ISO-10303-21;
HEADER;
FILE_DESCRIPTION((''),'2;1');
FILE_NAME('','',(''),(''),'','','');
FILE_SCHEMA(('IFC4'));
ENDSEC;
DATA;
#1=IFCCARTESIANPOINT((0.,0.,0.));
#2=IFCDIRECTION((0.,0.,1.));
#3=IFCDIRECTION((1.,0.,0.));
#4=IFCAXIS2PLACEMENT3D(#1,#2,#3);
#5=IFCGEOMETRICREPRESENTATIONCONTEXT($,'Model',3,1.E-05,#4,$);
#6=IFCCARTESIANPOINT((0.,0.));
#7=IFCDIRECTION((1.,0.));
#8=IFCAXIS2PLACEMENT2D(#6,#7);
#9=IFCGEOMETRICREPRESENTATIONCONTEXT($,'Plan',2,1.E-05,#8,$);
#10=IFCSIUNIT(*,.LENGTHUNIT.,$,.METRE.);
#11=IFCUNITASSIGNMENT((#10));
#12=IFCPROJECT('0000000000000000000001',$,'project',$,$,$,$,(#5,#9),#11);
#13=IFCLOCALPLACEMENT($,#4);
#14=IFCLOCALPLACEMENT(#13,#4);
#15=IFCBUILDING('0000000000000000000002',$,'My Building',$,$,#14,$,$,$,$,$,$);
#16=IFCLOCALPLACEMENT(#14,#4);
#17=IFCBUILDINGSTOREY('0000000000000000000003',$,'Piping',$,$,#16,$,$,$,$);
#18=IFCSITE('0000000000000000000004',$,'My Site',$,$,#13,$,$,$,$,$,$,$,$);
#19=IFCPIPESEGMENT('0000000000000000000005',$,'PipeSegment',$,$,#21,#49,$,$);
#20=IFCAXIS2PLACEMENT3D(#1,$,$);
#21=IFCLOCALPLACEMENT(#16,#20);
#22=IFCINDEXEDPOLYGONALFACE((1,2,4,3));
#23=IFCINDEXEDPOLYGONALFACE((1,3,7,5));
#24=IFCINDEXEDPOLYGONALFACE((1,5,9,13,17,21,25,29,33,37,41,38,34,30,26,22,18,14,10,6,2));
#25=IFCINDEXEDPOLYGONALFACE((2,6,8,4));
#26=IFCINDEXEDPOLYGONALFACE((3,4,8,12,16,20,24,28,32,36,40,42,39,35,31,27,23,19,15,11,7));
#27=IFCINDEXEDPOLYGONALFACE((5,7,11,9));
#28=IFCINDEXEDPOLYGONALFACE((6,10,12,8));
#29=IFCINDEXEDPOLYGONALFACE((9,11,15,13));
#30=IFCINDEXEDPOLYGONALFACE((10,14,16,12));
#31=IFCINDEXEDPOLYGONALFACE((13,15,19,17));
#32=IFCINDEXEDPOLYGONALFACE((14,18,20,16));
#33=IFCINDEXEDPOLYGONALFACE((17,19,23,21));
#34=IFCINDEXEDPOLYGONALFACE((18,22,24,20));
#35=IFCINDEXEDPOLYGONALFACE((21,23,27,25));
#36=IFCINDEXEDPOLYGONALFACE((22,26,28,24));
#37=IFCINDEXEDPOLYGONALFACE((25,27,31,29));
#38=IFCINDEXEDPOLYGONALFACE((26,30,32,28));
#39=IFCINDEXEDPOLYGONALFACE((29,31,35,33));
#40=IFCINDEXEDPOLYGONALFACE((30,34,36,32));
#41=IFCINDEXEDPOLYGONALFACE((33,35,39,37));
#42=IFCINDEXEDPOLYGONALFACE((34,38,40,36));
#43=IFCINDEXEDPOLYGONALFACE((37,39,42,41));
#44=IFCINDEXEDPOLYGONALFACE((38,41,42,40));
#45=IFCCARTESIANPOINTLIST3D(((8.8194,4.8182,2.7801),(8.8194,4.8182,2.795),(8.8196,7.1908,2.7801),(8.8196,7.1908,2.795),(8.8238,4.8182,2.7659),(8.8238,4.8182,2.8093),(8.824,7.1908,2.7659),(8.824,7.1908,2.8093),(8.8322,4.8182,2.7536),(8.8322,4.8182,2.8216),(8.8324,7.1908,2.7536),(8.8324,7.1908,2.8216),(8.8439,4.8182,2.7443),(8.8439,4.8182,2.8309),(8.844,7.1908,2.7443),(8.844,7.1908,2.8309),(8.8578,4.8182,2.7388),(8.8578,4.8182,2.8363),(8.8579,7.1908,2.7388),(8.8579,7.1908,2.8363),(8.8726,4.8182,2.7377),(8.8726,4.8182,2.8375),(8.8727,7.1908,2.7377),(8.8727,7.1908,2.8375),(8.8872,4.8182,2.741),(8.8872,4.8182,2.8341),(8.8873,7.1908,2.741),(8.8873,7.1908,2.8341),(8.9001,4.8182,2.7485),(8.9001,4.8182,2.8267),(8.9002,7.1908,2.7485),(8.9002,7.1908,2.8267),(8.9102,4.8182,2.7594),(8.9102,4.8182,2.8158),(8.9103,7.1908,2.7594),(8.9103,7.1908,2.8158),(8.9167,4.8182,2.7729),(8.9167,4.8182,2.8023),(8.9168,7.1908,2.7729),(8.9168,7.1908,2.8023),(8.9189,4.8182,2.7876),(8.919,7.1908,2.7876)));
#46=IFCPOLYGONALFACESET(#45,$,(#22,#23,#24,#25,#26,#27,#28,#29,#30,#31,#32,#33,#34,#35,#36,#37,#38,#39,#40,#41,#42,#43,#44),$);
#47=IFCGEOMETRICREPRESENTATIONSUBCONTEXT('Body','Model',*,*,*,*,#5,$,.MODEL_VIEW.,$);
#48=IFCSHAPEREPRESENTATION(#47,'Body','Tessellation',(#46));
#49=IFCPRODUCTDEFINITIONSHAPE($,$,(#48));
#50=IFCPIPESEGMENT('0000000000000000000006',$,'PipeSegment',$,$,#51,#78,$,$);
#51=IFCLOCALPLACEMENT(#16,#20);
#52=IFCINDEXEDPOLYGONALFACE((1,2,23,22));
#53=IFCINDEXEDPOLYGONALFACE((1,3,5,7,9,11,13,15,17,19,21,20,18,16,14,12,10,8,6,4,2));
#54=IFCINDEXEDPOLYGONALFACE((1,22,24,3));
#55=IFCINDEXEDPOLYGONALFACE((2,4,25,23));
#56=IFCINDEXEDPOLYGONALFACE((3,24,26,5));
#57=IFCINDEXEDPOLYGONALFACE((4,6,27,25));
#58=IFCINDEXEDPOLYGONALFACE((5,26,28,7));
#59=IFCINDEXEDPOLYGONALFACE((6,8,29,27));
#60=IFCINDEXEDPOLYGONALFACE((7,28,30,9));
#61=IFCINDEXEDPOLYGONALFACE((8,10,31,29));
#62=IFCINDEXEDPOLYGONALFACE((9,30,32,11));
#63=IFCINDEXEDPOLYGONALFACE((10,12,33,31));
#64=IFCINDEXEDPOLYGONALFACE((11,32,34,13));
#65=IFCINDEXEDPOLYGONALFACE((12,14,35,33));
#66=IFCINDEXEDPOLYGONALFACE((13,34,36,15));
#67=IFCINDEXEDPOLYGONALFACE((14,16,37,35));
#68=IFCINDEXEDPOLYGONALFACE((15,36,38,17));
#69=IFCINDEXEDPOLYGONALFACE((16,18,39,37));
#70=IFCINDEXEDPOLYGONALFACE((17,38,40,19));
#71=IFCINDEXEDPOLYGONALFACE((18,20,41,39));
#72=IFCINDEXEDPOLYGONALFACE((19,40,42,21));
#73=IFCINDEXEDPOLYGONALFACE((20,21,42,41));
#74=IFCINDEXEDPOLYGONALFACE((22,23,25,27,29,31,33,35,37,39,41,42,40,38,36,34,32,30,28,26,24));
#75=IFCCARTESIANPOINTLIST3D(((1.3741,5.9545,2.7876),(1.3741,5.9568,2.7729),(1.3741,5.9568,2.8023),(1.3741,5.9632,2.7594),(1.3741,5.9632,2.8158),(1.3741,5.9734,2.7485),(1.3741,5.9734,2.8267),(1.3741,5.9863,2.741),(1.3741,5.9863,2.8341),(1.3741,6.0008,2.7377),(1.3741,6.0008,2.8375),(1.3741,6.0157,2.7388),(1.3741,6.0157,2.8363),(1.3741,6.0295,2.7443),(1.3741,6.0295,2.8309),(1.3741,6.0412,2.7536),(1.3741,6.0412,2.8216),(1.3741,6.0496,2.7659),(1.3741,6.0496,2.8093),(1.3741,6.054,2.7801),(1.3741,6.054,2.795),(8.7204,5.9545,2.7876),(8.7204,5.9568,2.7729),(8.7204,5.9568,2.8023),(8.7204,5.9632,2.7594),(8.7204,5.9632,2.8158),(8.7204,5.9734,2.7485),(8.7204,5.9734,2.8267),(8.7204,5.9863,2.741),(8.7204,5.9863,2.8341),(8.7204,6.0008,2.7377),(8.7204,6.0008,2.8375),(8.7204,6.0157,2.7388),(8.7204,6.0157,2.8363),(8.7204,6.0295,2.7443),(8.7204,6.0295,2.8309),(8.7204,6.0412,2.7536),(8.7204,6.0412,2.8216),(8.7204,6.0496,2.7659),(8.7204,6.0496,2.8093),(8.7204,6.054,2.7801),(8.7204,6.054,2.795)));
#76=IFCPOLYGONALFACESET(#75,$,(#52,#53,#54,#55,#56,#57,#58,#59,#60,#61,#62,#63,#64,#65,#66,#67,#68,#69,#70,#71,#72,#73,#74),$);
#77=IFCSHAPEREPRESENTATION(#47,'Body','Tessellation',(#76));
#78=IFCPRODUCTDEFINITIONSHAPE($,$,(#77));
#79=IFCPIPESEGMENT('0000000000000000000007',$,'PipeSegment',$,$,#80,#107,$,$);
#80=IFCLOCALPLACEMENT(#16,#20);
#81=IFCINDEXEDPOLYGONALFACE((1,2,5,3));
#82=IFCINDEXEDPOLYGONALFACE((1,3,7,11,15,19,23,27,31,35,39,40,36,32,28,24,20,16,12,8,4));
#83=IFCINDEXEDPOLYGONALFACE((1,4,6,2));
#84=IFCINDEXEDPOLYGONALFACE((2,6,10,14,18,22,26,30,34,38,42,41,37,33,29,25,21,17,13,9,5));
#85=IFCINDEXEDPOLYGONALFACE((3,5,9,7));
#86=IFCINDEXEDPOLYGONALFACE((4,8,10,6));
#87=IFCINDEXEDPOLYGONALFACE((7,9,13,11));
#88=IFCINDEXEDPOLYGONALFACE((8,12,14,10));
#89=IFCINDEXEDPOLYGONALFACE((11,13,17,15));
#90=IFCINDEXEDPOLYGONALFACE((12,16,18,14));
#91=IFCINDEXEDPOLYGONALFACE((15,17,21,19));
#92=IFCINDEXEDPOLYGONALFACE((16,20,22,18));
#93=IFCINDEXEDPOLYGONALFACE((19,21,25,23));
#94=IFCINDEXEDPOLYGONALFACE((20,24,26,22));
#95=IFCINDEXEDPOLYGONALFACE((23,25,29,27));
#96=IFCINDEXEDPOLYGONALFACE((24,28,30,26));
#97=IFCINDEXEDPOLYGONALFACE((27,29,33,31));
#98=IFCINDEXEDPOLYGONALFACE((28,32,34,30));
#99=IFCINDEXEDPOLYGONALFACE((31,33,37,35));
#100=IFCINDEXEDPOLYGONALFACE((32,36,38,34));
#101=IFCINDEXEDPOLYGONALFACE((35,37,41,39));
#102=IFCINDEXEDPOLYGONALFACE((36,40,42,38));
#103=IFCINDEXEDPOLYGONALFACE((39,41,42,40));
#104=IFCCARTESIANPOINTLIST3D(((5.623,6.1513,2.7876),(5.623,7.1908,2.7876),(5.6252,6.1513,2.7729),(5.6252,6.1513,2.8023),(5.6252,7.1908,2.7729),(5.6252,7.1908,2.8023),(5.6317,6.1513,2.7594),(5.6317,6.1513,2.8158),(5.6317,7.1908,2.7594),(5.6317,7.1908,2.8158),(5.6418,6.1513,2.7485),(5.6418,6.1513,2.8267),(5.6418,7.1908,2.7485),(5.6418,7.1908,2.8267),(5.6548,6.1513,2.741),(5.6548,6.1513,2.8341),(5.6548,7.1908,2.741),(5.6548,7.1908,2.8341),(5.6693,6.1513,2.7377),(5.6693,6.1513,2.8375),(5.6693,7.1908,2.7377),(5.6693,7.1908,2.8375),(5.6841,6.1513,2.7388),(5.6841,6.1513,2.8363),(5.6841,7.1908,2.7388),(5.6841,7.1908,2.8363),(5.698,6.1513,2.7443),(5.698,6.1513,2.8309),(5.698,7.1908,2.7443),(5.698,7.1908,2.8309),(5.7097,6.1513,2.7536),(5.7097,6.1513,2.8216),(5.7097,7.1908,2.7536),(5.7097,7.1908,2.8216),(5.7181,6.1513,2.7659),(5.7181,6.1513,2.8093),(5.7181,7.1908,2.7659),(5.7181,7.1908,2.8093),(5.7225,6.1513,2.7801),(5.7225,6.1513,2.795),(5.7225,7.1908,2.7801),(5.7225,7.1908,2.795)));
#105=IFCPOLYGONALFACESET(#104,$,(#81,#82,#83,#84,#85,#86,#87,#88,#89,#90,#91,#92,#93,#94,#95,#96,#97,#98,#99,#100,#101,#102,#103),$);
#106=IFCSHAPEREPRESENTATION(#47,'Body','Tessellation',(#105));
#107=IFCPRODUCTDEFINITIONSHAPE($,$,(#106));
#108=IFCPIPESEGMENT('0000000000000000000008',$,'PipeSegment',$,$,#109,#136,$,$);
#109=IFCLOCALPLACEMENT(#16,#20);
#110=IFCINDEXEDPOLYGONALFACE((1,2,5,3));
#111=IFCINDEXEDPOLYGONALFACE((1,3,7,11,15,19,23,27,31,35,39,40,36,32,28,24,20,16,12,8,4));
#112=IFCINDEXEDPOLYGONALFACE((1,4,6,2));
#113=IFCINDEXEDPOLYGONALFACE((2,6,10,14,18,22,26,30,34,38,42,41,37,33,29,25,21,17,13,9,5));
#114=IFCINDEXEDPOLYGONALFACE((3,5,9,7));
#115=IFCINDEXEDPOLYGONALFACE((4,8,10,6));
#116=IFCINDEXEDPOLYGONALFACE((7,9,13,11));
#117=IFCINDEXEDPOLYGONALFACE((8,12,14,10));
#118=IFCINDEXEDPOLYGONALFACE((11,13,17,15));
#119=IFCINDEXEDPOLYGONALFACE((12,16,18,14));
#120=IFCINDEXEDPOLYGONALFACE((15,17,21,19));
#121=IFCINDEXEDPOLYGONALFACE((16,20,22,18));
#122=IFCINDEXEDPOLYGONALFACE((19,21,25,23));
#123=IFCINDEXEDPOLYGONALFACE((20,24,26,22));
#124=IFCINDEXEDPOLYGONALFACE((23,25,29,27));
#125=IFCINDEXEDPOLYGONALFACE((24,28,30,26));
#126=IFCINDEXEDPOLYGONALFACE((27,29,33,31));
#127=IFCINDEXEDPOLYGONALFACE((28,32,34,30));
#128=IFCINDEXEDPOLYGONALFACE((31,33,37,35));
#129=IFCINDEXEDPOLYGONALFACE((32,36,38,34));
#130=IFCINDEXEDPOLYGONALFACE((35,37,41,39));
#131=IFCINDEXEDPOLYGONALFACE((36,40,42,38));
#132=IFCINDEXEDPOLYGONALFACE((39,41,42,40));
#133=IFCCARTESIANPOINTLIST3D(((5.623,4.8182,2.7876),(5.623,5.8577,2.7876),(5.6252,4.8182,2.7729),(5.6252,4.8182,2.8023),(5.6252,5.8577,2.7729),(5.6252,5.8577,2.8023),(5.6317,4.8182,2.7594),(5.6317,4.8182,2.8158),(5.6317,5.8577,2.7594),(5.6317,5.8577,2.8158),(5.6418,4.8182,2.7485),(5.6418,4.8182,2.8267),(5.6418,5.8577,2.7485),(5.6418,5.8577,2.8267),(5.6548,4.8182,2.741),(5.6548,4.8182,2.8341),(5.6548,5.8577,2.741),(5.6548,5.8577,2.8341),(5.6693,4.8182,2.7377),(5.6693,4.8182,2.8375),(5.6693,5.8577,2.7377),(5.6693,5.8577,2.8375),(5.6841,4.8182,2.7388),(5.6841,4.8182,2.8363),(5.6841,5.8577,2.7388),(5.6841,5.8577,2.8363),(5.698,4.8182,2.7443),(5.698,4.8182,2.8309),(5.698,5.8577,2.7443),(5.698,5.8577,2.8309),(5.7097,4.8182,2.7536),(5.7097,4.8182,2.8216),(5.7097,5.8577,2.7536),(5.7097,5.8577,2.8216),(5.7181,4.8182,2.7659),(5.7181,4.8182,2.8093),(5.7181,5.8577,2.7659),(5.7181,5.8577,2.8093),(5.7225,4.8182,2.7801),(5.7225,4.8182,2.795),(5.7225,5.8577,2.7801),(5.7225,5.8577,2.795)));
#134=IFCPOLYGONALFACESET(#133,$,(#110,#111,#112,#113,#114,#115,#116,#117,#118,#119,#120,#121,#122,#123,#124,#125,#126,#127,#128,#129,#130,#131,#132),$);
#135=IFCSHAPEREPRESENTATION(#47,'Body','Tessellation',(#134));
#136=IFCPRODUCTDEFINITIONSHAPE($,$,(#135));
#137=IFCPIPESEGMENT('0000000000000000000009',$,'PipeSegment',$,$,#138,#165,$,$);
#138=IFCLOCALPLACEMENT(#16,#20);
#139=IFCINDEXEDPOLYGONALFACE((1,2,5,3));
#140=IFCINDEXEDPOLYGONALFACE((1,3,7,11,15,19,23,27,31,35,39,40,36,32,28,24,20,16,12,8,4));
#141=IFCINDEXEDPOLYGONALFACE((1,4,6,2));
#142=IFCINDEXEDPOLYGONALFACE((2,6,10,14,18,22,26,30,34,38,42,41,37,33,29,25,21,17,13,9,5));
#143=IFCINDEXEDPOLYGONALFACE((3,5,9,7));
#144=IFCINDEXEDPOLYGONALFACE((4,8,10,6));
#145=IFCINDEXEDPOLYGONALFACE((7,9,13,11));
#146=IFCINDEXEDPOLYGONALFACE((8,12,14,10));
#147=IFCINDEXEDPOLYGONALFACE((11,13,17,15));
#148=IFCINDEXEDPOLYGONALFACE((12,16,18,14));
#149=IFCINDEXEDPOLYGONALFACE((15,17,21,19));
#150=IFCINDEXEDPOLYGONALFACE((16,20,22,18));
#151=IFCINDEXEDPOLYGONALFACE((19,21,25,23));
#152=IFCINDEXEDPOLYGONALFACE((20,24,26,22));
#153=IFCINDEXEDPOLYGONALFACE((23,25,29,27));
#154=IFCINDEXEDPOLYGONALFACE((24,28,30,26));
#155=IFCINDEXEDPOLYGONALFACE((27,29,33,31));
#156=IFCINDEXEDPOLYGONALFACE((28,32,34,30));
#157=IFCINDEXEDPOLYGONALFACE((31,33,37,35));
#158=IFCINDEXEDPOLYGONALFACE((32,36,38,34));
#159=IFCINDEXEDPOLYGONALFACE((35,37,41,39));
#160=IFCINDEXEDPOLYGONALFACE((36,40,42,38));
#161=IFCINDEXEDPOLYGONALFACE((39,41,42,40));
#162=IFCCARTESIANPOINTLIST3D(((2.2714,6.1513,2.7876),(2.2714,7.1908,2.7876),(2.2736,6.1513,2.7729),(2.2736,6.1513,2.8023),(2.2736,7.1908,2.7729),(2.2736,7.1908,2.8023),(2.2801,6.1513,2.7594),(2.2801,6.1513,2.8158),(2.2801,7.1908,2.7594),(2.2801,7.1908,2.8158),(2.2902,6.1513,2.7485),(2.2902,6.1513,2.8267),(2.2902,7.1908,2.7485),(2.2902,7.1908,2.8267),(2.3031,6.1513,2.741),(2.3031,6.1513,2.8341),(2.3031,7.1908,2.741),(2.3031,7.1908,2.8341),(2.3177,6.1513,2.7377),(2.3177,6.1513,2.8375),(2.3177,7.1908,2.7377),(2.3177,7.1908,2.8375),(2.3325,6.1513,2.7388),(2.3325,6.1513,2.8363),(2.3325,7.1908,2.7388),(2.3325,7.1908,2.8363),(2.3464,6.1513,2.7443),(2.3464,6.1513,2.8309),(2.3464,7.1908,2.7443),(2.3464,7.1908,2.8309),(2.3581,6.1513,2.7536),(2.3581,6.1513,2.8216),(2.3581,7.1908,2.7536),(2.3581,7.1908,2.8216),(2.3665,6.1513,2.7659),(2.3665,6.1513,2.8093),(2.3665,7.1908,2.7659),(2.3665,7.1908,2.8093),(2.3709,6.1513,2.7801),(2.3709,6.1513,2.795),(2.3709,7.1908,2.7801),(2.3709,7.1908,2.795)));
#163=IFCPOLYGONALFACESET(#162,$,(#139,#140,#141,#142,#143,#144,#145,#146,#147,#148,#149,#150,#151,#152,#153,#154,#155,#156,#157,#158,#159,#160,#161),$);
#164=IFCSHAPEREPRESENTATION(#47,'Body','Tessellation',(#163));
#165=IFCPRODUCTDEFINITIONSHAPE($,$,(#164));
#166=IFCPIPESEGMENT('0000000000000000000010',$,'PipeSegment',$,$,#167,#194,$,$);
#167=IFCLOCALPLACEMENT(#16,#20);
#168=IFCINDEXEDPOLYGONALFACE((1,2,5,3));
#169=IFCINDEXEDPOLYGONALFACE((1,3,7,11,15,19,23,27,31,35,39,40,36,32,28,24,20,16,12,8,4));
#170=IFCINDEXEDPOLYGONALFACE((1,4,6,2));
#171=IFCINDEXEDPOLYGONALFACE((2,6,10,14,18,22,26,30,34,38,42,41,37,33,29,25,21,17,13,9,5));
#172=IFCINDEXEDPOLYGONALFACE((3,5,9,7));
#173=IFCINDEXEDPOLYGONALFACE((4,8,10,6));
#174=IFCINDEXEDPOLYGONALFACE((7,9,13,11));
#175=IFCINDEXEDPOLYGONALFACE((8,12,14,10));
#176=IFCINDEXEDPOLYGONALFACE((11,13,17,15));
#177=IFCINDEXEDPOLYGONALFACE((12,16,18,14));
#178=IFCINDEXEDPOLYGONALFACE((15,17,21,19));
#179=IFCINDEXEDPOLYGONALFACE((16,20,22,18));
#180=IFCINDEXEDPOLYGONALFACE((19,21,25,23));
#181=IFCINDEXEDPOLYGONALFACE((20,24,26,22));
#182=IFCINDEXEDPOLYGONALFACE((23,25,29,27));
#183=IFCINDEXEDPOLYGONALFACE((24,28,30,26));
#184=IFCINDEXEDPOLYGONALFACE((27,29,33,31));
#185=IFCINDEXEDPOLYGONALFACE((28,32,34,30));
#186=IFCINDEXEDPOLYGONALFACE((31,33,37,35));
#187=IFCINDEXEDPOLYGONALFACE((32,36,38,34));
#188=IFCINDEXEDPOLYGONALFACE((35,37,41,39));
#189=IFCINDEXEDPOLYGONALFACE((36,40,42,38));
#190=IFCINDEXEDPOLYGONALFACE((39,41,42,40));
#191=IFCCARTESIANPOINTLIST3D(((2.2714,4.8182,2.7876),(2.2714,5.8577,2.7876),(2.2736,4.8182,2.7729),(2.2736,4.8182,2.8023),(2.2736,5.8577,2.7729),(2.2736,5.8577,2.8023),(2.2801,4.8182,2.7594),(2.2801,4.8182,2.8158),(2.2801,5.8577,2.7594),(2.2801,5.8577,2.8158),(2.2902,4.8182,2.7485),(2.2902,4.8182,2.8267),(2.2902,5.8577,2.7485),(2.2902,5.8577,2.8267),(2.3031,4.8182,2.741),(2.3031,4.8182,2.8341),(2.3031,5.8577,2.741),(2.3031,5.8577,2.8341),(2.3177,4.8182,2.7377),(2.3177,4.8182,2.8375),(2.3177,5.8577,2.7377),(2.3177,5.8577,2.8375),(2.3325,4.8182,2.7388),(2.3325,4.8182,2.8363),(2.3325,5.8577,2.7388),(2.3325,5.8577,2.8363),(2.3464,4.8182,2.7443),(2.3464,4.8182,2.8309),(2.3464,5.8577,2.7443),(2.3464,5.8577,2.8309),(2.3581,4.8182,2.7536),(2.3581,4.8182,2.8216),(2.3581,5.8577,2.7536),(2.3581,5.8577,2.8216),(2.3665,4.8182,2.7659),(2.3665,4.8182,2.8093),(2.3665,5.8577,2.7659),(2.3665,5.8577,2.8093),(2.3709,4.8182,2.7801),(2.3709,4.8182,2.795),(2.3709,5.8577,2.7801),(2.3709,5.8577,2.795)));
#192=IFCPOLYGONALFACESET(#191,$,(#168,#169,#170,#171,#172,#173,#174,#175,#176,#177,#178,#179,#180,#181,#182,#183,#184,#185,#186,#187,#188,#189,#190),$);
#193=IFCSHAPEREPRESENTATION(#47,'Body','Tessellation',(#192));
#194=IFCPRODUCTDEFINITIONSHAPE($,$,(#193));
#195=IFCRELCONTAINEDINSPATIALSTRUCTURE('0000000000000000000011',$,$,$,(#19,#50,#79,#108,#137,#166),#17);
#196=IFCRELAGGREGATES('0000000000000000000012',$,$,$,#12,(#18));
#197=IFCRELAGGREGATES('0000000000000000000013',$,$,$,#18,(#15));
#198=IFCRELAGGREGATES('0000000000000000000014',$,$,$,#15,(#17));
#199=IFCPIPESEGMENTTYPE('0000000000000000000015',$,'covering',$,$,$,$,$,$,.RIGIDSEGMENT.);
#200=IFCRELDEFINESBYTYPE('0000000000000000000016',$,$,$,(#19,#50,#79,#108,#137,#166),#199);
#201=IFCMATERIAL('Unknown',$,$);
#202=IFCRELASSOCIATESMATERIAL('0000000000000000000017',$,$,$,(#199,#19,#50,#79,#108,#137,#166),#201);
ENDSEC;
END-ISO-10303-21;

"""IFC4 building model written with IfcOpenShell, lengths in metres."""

from ifc_helpers import new_model, si_unit, frame, origin_with_axes, origin_2d_with_axis, place, context, subcontext, project, spatial, circle, extrude, material, material_profile, profile_set, profile_usage, type_object, element, save


model = new_model("IFC4")

# Units and contexts
model_context = context("Model", 3, precision=1e-05, world=origin_with_axes())
plan_context = context("Plan", 2, precision=1e-05, world=origin_2d_with_axis())
body_context = subcontext(model_context, "Body", "Model", "MODEL_VIEW")
ifc_project = project(units=[si_unit("LENGTHUNIT", "METRE")], contexts=[model_context, plan_context])

# Site, building, storey
site_placement = place(None, origin_with_axes())
site = spatial("IfcSite", under=ifc_project, at=site_placement, Name="My Site")
building_placement = place(site_placement, origin_with_axes())
building = spatial("IfcBuilding", under=site, at=building_placement, Name="My Building")
storey_placement = place(building_placement, origin_with_axes())
storey = spatial("IfcBuildingStorey", under=building, at=storey_placement, Name="Piping")

# Pipe segments
ifc_material = material(Name="Unknown")
ifc_material_profile_1 = material_profile(ifc_material, circle(Radius=0.05))
ifc_profile_set_1 = profile_set([ifc_material_profile_1])
ifc_profile_usage_1 = profile_usage(ifc_profile_set_1, cardinal=5)
pipe_segment_type = type_object("IfcPipeSegmentType", Name="covering", PredefinedType="RIGIDSEGMENT", material=ifc_profile_set_1)
pipe_segment_1_placement = place(storey_placement, frame((8.869, 7.1908, 2.7876), z_axis=(-0.000052, -1.0, 0.0), x_axis=(1.0, -0.000052, 0.0)))
element("IfcPipeSegment", 1, at=pipe_segment_1_placement, inside=storey, type_object=pipe_segment_type, material=ifc_profile_usage_1, Name="PipeSegment", context=body_context, shape_type="SweptSolid", body=[
    extrude(circle(Radius=0.05), origin_with_axes(), (0.0, 0.0, 1.0), 2.3727),
])
ifc_profile_usage_2 = profile_usage(ifc_profile_set_1, cardinal=5)
pipe_segment_2_placement = place(storey_placement, frame((8.7204, 6.0045, 2.7876), z_axis=(-1.0, 0.0, 0.0), x_axis=(0.0, -1.0, 0.0)))
element("IfcPipeSegment", 2, at=pipe_segment_2_placement, inside=storey, type_object=pipe_segment_type, material=ifc_profile_usage_2, Name="PipeSegment", context=body_context, shape_type="SweptSolid", body=[
    extrude(circle(Radius=0.05), origin_with_axes(), (0.0, 0.0, 1.0), 7.3463),
])
ifc_profile_usage_3 = profile_usage(ifc_profile_set_1, cardinal=5)
pipe_segment_3_placement = place(storey_placement, frame((5.673, 6.1513, 2.7876), z_axis=(0.0, 1.0, 0.0), x_axis=(-1.0, 0.0, 0.0)))
element("IfcPipeSegment", 3, at=pipe_segment_3_placement, inside=storey, type_object=pipe_segment_type, material=ifc_profile_usage_3, Name="PipeSegment", context=body_context, shape_type="SweptSolid", body=[
    extrude(circle(Radius=0.05), origin_with_axes(), (0.0, 0.0, 1.0), 1.0396),
])
ifc_profile_usage_4 = profile_usage(ifc_profile_set_1, cardinal=5)
pipe_segment_4_placement = place(storey_placement, frame((5.673, 4.8182, 2.7876), z_axis=(0.0, 1.0, 0.0), x_axis=(-1.0, 0.0, 0.0)))
element("IfcPipeSegment", 4, at=pipe_segment_4_placement, inside=storey, type_object=pipe_segment_type, material=ifc_profile_usage_4, Name="PipeSegment", context=body_context, shape_type="SweptSolid", body=[
    extrude(circle(Radius=0.05), origin_with_axes(), (0.0, 0.0, 1.0), 1.0396),
])
ifc_profile_usage_5 = profile_usage(ifc_profile_set_1, cardinal=5)
pipe_segment_5_placement = place(storey_placement, frame((2.3214, 6.1513, 2.7876), z_axis=(0.0, 1.0, 0.0), x_axis=(-1.0, 0.0, 0.0)))
element("IfcPipeSegment", 5, at=pipe_segment_5_placement, inside=storey, type_object=pipe_segment_type, material=ifc_profile_usage_5, Name="PipeSegment", context=body_context, shape_type="SweptSolid", body=[
    extrude(circle(Radius=0.05), origin_with_axes(), (0.0, 0.0, 1.0), 1.0396),
])
ifc_profile_usage_6 = profile_usage(ifc_profile_set_1, cardinal=5)
pipe_segment_6_placement = place(storey_placement, frame((2.3214, 4.8182, 2.7876), z_axis=(0.0, 1.0, 0.0), x_axis=(-1.0, 0.0, 0.0)))
element("IfcPipeSegment", 6, at=pipe_segment_6_placement, inside=storey, type_object=pipe_segment_type, material=ifc_profile_usage_6, Name="PipeSegment", context=body_context, shape_type="SweptSolid", body=[
    extrude(circle(Radius=0.05), origin_with_axes(), (0.0, 0.0, 1.0), 1.0396),
])

save(model, "model.ifc")
